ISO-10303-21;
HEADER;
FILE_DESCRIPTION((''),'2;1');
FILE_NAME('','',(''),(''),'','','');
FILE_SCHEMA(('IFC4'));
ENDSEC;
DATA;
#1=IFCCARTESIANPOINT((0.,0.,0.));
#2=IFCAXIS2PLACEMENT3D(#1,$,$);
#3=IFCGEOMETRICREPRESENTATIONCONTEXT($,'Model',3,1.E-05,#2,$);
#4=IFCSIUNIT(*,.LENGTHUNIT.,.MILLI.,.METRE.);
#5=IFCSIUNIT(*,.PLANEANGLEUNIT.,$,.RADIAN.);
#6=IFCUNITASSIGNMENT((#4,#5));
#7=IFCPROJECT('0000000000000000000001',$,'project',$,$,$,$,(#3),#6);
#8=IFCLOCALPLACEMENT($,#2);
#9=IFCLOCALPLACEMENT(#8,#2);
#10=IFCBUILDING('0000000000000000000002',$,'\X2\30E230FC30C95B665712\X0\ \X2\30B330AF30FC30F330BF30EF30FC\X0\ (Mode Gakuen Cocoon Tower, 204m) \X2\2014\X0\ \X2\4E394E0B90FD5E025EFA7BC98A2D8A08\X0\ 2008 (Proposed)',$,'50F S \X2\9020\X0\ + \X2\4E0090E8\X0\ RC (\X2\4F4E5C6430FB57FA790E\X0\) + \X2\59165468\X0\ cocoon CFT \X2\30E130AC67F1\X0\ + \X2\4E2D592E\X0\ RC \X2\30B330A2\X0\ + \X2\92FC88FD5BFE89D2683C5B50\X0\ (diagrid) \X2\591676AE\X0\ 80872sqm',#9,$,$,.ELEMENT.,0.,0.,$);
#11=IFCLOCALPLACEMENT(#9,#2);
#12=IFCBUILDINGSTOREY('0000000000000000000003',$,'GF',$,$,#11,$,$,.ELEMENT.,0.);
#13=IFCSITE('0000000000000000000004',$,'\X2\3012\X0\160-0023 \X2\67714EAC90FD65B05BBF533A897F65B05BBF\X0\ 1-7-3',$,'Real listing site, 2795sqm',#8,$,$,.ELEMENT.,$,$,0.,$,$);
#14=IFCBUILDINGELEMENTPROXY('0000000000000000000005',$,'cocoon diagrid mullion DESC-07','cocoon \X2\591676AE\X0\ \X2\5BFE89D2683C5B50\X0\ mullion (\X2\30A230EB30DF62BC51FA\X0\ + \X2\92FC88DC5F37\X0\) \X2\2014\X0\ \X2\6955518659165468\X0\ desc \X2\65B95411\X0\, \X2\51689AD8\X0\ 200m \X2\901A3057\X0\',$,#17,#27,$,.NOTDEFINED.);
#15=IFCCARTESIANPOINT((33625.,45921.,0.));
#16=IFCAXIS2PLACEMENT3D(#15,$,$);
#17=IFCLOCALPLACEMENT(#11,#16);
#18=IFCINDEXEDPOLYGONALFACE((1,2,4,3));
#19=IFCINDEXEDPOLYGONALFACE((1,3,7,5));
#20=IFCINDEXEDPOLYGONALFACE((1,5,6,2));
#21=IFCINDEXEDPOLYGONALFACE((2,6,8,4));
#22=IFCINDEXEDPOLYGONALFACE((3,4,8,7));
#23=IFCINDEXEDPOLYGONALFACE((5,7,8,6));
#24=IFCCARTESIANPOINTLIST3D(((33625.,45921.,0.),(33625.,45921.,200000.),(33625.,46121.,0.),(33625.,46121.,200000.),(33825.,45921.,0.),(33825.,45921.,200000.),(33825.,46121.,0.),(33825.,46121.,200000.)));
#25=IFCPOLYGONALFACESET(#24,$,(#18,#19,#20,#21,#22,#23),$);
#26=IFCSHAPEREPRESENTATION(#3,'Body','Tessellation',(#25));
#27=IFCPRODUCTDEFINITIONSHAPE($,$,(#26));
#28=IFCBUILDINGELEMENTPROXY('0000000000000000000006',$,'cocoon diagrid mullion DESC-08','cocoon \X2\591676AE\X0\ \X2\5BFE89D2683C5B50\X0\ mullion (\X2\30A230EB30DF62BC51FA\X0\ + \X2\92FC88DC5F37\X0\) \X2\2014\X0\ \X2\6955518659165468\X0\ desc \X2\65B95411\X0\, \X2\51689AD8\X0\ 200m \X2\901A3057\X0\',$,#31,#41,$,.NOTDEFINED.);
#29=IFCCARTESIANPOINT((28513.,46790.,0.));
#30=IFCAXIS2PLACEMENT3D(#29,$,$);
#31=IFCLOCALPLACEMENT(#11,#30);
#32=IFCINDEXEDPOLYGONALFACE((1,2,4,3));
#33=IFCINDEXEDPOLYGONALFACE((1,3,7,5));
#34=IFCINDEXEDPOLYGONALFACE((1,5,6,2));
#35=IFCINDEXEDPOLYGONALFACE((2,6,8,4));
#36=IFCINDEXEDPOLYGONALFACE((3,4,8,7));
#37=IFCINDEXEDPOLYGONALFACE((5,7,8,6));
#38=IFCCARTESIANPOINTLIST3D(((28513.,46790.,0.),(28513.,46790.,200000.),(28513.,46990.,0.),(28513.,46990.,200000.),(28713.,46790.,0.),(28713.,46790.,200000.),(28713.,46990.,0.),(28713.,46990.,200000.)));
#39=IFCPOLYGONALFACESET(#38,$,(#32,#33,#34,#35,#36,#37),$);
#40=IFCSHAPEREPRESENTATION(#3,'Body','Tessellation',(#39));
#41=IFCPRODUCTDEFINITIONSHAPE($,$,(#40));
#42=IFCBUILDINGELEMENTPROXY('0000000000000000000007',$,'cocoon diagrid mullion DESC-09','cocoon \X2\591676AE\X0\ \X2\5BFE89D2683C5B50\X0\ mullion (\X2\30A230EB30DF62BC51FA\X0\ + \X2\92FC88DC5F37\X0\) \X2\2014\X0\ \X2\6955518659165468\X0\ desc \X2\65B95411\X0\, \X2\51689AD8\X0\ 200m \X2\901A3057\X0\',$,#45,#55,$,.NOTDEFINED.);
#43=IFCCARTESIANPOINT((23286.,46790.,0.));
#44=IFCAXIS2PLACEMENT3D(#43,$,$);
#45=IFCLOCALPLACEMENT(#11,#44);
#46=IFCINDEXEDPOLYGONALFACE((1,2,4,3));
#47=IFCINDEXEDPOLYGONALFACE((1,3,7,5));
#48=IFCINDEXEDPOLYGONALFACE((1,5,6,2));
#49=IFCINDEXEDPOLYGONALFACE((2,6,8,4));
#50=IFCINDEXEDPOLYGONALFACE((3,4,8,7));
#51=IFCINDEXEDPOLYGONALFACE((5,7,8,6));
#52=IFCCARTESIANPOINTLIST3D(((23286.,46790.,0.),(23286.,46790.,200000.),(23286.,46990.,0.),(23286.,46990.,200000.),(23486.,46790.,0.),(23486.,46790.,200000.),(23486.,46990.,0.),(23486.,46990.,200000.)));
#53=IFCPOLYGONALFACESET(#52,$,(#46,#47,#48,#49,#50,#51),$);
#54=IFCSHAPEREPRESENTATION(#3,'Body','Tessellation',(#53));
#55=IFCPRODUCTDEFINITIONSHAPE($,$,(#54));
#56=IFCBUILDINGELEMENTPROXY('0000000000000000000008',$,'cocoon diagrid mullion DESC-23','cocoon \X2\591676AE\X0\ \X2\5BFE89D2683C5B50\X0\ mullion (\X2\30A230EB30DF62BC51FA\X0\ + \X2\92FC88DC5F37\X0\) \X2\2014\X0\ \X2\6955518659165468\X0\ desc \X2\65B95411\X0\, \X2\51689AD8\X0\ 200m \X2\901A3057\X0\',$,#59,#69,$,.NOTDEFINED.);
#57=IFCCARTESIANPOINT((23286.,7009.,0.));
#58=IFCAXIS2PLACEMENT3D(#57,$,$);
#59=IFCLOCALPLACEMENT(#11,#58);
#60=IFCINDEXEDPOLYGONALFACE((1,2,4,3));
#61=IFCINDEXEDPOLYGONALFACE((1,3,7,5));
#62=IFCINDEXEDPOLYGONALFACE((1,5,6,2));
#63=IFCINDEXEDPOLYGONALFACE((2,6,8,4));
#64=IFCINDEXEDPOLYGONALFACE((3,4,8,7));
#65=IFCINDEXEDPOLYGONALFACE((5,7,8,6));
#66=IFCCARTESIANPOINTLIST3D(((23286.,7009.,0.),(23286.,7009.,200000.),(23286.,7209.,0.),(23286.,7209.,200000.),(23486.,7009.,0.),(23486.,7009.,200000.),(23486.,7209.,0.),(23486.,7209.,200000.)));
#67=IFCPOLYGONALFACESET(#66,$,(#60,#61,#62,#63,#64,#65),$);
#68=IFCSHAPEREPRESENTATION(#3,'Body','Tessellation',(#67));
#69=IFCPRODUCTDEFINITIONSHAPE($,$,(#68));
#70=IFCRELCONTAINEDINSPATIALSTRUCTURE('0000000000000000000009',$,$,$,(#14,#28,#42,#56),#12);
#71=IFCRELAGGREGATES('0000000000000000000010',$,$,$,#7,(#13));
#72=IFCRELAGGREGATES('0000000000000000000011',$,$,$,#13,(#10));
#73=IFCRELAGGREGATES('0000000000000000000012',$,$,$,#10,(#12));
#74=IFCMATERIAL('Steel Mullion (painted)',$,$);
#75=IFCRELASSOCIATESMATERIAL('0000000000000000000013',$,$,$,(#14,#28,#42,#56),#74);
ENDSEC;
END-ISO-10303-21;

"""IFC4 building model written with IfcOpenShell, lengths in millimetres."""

from ifc_helpers import new_model, si_unit, frame, frame_2d, origin, place, context, project, spatial, rectangle, extrude, material, element, save


model = new_model("IFC4")

# Units and contexts
model_context = context("Model", 3, precision=1e-05, world=origin())
ifc_project = project(units=[si_unit("LENGTHUNIT", "METRE", prefix="MILLI"), si_unit("PLANEANGLEUNIT", "RADIAN")], contexts=[model_context])

# Site, building, storey
site_placement = place(None, origin())
site = spatial("IfcSite", under=ifc_project, at=site_placement, Name="〒160-0023 東京都新宿区西新宿 1-7-3", ObjectType="Real listing site, 2795sqm", CompositionType="ELEMENT", RefElevation=0.0)
building_placement = place(site_placement, origin())
building = spatial("IfcBuilding", under=site, at=building_placement, Name="モード学園 コクーンタワー (Mode Gakuen Cocoon Tower, 204m) — 丹下都市建築設計 2008 (Proposed)", ObjectType="50F S 造 + 一部 RC (低層・基礎) + 外周 cocoon CFT メガ柱 + 中央 RC コア + 鋼製対角格子 (diagrid) 外皮 80872sqm", CompositionType="ELEMENT", ElevationOfRefHeight=0.0, ElevationOfTerrain=0.0)
storey_placement = place(building_placement, origin())
storey = spatial("IfcBuildingStorey", under=building, at=storey_placement, Name="GF", CompositionType="ELEMENT", Elevation=0.0)

# Building element proxies
ifc_material_1 = material(Name="Steel Mullion (painted)")
proxy_1_placement = place(storey_placement, frame((33625.0, 45921.0, 0.0)))
element("IfcBuildingElementProxy", 1, at=proxy_1_placement, inside=storey, material=ifc_material_1, Name="cocoon diagrid mullion DESC-07", Description="cocoon 外皮 対角格子 mullion (アルミ押出 + 鋼補強) — 楕円外周 desc 方向, 全高 200m 通し", PredefinedType="NOTDEFINED", context=model_context, shape_type="SweptSolid", body=[
    extrude(rectangle(XDim=200.0, YDim=200.0, at=frame_2d((100.0, 100.0))), frame((33625.0, 45921.0, 0.0)), (0.0, 0.0, 1.0), 200000.0),
])
proxy_2_placement = place(storey_placement, frame((28513.0, 46790.0, 0.0)))
element("IfcBuildingElementProxy", 2, at=proxy_2_placement, inside=storey, material=ifc_material_1, Name="cocoon diagrid mullion DESC-08", Description="cocoon 外皮 対角格子 mullion (アルミ押出 + 鋼補強) — 楕円外周 desc 方向, 全高 200m 通し", PredefinedType="NOTDEFINED", context=model_context, shape_type="SweptSolid", body=[
    extrude(rectangle(XDim=200.0, YDim=200.0, at=frame_2d((100.0, 100.0))), frame((28513.0, 46790.0, 0.0)), (0.0, 0.0, 1.0), 200000.0),
])
proxy_3_placement = place(storey_placement, frame((23286.0, 46790.0, 0.0)))
element("IfcBuildingElementProxy", 3, at=proxy_3_placement, inside=storey, material=ifc_material_1, Name="cocoon diagrid mullion DESC-09", Description="cocoon 外皮 対角格子 mullion (アルミ押出 + 鋼補強) — 楕円外周 desc 方向, 全高 200m 通し", PredefinedType="NOTDEFINED", context=model_context, shape_type="SweptSolid", body=[
    extrude(rectangle(XDim=200.0, YDim=200.0, at=frame_2d((100.0, 100.0))), frame((23286.0, 46790.0, 0.0)), (0.0, 0.0, 1.0), 200000.0),
])
proxy_4_placement = place(storey_placement, frame((23286.0, 7009.0, 0.0)))
element("IfcBuildingElementProxy", 4, at=proxy_4_placement, inside=storey, material=ifc_material_1, Name="cocoon diagrid mullion DESC-23", Description="cocoon 外皮 対角格子 mullion (アルミ押出 + 鋼補強) — 楕円外周 desc 方向, 全高 200m 通し", PredefinedType="NOTDEFINED", context=model_context, shape_type="SweptSolid", body=[
    extrude(rectangle(XDim=200.0, YDim=200.0, at=frame_2d((100.0, 100.0))), frame((23286.0, 7009.0, 0.0)), (0.0, 0.0, 1.0), 200000.0),
])

save(model, "model.ifc")
